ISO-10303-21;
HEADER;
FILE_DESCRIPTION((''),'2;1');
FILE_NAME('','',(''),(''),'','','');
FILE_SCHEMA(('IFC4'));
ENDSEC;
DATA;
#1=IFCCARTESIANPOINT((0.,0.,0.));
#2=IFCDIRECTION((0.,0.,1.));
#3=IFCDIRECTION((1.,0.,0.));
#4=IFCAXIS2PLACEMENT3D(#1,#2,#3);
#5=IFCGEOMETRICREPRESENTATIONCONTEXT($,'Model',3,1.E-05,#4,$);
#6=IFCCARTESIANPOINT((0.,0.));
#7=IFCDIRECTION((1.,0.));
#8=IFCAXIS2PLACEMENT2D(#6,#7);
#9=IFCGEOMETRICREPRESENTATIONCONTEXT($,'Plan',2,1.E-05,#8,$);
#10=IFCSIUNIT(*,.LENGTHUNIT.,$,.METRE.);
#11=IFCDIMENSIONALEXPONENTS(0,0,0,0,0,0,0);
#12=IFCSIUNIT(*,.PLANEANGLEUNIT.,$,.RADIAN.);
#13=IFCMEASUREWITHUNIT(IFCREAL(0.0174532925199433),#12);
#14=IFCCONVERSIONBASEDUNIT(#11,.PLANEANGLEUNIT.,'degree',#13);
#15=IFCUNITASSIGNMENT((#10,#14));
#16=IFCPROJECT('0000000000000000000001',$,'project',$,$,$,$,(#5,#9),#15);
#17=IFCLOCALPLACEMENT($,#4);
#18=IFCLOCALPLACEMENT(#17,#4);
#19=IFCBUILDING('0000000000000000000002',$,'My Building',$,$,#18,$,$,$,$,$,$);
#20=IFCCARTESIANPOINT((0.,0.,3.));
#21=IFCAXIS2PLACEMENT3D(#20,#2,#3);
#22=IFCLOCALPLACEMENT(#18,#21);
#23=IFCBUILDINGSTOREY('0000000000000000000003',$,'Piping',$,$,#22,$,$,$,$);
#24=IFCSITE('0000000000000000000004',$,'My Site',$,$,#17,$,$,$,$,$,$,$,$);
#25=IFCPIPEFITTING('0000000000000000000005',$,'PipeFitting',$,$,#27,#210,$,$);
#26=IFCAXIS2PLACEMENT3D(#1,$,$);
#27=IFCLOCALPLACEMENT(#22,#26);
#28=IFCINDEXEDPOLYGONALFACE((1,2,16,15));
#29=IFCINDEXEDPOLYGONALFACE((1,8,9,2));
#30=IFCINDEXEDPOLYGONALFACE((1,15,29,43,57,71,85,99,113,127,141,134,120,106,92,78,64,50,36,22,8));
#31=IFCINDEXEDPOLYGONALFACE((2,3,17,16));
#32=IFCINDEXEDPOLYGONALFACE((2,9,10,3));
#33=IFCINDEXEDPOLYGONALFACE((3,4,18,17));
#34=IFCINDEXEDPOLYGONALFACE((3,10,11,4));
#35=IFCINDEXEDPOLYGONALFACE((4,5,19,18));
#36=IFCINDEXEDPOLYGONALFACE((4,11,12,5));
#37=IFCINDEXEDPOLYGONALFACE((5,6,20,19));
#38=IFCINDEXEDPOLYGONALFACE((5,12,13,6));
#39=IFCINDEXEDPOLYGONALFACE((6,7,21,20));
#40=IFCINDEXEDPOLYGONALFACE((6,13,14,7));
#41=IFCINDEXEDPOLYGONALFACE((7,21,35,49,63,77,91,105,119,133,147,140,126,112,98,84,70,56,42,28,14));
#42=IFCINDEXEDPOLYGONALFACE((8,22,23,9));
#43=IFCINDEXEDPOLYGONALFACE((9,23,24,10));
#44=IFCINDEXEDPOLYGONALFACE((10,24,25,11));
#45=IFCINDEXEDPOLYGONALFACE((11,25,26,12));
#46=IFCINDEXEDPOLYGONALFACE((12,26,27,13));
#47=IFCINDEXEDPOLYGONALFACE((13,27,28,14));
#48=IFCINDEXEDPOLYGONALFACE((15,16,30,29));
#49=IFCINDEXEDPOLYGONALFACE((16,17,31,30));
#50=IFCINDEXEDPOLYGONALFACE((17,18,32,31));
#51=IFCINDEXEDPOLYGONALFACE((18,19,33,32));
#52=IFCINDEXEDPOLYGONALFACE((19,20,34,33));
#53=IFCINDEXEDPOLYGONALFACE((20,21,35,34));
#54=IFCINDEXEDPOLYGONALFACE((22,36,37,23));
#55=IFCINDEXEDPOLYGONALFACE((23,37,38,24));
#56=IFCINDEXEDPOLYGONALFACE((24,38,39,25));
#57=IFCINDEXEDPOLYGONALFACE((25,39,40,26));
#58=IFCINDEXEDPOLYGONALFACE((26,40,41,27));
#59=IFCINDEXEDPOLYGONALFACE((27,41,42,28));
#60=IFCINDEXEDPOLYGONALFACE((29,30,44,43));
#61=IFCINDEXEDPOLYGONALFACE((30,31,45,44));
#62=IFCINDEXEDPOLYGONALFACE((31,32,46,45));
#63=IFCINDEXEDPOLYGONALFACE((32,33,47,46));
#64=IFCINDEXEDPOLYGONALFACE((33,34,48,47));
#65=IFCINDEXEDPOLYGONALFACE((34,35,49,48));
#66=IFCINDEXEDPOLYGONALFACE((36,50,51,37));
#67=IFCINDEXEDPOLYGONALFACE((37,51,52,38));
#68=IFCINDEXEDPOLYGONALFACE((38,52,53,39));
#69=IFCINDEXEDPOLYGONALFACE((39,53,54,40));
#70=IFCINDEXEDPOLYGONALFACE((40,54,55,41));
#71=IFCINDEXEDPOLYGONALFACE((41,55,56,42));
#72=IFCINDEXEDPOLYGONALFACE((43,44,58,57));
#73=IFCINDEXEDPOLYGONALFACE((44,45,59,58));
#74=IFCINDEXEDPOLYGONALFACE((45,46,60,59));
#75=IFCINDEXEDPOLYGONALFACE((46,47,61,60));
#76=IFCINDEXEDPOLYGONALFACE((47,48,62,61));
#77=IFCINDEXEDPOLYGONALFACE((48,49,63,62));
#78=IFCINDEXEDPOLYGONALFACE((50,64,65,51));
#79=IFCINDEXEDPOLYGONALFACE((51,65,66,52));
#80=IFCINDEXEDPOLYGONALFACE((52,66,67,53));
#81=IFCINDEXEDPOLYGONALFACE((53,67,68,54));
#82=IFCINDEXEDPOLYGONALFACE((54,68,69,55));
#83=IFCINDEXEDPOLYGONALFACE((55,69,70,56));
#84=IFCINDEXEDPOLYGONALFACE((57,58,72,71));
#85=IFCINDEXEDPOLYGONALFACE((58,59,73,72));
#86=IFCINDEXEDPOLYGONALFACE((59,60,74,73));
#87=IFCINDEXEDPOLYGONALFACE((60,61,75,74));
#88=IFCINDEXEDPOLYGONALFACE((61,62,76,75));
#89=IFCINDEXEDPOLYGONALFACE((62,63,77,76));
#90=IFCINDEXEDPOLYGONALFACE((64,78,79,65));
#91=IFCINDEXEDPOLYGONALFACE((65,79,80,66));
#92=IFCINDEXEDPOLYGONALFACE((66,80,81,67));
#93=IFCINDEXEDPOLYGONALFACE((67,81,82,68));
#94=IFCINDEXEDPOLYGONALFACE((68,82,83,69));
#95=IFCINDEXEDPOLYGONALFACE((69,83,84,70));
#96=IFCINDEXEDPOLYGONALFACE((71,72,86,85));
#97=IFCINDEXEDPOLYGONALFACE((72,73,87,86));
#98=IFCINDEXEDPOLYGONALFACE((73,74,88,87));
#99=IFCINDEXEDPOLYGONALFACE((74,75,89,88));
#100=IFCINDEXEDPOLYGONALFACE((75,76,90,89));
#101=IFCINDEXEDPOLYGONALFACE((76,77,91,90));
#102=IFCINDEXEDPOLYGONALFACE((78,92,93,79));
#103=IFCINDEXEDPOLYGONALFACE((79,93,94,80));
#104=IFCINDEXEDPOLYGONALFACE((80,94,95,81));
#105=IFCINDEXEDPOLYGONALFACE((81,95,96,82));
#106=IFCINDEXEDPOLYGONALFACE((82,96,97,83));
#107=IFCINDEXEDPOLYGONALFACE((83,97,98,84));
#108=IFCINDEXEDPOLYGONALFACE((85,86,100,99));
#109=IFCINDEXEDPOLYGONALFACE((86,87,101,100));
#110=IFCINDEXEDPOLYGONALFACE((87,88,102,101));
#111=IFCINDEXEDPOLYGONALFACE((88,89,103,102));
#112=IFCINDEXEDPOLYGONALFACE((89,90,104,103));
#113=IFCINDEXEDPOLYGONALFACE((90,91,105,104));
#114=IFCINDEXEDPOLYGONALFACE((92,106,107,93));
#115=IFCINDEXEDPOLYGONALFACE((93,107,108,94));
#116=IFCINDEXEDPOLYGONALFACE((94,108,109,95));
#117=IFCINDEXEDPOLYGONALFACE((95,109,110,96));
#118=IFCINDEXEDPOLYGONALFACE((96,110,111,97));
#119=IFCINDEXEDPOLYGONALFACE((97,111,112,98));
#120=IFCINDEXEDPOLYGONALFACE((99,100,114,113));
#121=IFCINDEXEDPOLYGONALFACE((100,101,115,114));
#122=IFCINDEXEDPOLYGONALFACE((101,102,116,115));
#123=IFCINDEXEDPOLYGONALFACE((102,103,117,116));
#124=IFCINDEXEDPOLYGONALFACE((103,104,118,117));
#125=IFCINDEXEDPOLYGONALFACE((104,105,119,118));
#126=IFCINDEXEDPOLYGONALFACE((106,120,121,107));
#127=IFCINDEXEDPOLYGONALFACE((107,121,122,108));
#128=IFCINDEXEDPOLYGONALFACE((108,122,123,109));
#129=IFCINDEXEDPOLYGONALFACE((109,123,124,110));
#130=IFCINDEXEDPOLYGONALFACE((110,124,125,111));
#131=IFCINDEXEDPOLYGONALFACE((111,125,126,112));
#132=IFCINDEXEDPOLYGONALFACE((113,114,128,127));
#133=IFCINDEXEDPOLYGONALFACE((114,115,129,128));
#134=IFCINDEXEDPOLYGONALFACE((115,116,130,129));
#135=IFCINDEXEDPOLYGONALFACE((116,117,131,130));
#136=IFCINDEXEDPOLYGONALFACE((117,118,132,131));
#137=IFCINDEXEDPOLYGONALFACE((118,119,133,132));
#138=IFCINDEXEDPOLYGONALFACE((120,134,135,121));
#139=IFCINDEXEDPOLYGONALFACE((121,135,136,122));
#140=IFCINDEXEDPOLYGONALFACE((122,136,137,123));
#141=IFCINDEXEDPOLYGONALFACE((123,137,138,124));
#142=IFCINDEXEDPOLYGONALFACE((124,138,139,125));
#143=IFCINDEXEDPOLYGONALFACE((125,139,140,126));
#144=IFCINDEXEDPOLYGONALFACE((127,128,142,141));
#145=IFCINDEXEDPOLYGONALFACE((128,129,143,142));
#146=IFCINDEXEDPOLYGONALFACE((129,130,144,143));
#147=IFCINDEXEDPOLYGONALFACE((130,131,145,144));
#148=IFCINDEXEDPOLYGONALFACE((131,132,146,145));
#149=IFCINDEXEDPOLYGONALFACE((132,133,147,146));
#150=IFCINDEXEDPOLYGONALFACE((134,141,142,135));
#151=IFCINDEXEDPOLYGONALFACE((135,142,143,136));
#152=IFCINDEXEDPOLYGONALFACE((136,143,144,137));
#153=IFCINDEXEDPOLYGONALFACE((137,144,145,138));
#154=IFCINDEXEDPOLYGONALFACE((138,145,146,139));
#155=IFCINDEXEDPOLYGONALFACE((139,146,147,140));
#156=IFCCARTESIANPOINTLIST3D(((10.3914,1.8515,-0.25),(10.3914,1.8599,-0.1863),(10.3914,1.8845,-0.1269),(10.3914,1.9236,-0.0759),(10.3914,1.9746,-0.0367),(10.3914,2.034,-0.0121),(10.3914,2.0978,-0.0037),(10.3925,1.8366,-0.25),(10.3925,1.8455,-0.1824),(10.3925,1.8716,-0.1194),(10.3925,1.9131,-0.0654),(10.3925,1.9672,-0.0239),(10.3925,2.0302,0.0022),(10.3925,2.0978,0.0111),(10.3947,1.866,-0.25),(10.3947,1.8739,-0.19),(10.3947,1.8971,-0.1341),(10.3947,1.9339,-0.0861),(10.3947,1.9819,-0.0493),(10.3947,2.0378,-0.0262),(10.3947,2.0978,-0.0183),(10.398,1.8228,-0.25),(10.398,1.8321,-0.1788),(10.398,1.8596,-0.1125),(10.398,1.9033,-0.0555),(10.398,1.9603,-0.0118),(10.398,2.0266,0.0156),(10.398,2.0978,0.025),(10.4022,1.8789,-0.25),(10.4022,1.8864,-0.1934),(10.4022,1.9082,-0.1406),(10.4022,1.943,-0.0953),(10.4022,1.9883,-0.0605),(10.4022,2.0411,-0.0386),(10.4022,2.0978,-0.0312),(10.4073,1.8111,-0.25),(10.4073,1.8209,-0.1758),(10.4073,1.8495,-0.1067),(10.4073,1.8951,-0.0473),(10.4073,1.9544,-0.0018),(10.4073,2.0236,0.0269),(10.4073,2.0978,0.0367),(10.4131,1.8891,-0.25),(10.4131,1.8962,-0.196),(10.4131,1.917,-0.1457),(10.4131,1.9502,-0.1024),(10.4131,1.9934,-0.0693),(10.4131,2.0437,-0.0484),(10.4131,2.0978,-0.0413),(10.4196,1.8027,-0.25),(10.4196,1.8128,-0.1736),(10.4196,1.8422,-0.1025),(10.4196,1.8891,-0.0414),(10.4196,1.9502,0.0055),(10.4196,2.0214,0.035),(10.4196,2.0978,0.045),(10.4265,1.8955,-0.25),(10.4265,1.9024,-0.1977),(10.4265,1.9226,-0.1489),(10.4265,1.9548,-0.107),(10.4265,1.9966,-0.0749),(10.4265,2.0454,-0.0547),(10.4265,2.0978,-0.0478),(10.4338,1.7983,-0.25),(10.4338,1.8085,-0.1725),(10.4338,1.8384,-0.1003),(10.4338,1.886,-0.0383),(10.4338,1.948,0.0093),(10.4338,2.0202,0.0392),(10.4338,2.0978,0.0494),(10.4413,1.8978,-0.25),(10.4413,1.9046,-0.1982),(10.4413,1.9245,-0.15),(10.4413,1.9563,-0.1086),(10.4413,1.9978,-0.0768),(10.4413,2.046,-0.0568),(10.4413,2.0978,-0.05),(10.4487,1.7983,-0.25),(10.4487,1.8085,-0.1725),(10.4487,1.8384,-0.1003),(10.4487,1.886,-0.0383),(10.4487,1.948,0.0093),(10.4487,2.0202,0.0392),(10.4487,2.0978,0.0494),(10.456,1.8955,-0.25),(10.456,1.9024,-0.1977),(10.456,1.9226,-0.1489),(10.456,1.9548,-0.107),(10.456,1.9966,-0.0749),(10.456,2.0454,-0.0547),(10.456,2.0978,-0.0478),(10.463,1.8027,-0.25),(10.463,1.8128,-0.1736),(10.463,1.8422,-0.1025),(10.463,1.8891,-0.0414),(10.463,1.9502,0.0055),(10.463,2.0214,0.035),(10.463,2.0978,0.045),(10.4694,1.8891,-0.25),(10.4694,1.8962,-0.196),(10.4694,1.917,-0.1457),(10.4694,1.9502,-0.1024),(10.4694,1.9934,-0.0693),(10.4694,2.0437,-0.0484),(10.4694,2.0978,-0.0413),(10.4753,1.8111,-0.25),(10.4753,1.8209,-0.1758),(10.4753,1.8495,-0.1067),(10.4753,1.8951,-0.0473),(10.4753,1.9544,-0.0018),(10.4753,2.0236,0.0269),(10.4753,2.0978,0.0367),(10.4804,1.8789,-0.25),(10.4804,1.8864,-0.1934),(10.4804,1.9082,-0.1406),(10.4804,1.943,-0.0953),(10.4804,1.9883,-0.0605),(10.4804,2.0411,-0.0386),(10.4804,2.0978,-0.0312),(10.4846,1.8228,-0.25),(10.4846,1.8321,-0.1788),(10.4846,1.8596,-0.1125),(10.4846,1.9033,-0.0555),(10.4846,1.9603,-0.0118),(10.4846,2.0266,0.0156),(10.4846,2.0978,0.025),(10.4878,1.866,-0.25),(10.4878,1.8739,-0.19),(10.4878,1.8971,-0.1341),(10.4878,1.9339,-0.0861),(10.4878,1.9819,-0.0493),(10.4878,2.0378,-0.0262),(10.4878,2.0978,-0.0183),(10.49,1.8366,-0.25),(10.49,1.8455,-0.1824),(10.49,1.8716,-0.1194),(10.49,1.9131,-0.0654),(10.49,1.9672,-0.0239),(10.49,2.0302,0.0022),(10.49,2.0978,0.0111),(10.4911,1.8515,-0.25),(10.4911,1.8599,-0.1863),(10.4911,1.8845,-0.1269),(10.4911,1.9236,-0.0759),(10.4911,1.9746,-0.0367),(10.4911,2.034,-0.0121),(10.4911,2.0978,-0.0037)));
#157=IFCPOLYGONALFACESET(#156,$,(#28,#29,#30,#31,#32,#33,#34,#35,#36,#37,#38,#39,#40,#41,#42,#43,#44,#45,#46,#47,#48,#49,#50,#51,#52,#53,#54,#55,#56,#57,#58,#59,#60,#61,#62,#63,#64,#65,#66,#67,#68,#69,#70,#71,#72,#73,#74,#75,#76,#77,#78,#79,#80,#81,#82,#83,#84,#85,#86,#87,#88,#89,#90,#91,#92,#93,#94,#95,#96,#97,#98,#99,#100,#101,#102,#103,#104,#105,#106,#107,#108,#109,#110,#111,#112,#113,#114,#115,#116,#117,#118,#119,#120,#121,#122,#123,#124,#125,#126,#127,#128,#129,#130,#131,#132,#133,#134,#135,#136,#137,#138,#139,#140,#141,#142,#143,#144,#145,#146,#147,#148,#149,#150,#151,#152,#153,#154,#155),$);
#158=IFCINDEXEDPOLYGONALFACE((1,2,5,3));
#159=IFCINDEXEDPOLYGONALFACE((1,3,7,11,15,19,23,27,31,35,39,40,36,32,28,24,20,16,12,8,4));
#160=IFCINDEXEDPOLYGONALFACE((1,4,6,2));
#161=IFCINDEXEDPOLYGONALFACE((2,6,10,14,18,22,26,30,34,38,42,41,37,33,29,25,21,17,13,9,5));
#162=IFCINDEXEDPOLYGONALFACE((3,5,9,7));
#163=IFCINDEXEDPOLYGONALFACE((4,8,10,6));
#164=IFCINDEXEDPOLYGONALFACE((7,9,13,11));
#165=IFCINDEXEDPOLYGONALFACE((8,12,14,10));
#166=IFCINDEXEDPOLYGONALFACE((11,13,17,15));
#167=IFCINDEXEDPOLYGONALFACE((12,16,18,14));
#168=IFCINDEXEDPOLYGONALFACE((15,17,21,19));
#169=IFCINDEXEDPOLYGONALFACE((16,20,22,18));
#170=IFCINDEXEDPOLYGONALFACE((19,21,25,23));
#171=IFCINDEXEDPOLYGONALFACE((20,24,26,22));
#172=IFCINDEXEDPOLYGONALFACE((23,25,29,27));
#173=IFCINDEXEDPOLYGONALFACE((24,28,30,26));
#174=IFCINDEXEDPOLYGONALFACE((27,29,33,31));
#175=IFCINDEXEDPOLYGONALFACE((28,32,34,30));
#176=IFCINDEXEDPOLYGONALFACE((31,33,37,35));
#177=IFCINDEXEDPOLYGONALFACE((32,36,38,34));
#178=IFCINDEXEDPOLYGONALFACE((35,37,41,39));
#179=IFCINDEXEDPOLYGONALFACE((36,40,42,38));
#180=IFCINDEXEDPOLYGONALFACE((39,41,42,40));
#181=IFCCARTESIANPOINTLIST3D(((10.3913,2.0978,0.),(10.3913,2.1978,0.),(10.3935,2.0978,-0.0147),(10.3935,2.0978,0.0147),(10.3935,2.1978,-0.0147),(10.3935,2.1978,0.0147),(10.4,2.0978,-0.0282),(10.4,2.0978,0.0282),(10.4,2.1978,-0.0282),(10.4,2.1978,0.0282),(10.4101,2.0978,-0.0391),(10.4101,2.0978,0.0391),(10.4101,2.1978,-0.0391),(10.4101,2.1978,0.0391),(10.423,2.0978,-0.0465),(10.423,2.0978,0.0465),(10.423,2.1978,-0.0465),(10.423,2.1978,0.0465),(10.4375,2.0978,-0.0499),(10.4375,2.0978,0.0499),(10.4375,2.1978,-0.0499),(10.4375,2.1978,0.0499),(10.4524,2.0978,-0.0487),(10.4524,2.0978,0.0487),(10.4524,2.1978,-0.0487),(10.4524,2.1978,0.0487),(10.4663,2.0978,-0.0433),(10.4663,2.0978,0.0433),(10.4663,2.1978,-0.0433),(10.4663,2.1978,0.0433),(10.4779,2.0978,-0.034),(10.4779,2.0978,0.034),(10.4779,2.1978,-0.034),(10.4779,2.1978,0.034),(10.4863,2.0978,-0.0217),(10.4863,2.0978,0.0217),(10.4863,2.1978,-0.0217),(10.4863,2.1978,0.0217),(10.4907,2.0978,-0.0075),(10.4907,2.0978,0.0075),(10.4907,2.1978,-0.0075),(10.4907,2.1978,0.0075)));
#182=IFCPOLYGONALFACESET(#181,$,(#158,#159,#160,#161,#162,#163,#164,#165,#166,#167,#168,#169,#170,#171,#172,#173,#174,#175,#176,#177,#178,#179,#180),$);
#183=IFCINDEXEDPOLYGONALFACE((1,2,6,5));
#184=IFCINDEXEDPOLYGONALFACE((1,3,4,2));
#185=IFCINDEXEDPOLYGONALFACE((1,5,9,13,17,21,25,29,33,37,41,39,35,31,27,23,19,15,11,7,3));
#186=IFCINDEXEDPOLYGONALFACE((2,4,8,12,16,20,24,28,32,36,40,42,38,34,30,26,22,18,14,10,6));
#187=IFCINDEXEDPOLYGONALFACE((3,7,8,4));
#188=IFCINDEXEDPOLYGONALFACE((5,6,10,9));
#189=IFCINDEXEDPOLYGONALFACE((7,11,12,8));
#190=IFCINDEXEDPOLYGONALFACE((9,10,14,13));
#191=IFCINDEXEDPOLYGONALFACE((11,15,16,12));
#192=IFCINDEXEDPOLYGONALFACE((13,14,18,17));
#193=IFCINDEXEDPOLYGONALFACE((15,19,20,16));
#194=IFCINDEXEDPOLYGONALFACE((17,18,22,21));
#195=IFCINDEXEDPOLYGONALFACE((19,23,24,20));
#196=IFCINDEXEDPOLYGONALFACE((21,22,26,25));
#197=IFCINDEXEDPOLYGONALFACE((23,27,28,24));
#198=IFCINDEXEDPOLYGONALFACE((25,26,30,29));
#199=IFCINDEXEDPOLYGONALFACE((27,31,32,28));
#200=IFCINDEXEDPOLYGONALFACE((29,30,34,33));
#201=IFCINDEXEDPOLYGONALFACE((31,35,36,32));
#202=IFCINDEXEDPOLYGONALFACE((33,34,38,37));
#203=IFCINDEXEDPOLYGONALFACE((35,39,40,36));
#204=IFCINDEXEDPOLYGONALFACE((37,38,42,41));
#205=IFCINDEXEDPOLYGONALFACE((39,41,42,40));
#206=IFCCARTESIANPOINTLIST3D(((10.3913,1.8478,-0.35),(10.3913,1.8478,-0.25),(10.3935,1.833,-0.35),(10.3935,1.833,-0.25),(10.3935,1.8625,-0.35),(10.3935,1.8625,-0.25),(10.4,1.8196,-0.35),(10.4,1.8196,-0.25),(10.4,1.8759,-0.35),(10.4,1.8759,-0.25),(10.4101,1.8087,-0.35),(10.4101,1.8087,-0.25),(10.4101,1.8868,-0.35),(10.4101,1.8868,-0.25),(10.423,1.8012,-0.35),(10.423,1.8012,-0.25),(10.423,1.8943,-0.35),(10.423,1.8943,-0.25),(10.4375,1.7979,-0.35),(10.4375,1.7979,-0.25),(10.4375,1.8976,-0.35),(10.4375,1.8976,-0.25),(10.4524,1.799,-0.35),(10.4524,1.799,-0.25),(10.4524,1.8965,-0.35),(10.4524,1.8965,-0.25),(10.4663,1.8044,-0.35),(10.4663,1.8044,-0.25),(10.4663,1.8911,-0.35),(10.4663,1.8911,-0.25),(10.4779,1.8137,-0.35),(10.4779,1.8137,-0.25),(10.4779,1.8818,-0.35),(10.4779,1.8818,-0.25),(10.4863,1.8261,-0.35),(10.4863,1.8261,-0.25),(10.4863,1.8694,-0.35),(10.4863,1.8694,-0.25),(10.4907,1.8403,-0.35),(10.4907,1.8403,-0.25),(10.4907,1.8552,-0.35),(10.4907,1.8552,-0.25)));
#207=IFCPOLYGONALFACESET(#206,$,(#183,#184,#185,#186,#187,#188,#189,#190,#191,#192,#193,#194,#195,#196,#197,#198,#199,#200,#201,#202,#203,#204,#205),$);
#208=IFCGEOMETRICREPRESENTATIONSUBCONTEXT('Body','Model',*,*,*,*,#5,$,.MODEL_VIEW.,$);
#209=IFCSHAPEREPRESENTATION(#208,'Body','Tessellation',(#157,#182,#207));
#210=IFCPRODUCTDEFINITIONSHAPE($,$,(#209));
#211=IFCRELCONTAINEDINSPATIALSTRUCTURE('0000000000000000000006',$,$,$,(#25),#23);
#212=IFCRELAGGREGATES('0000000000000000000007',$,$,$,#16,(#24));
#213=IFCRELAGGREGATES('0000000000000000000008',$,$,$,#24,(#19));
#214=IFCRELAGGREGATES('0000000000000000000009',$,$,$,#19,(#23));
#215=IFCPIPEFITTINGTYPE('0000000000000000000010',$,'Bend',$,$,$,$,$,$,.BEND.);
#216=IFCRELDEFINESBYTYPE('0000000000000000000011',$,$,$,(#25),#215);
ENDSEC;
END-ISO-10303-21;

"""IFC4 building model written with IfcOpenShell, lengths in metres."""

from ifc_helpers import new_model, entity, si_unit, converted_unit, frame, origin_with_axes, origin_2d_with_axis, place, context, subcontext, project, spatial, circle, extrude, source, transform, mapped, type_object, type_shapes, element, save


model = new_model("IFC4")

# Units and contexts
model_context = context("Model", 3, precision=1e-05, world=origin_with_axes())
plan_context = context("Plan", 2, precision=1e-05, world=origin_2d_with_axis())
body_context = subcontext(model_context, "Body", "Model", "MODEL_VIEW")
ifc_project = project(units=[si_unit("LENGTHUNIT", "METRE"), converted_unit("PLANEANGLEUNIT", "degree", entity("IfcReal", 0.0174532925199433), si_unit("PLANEANGLEUNIT", "RADIAN"), dimensions=[0, 0, 0, 0, 0, 0, 0])], contexts=[model_context, plan_context])

# Site, building, storey
site_placement = place(None, origin_with_axes())
site = spatial("IfcSite", under=ifc_project, at=site_placement, Name="My Site")
building_placement = place(site_placement, origin_with_axes())
building = spatial("IfcBuilding", under=site, at=building_placement, Name="My Building")
storey_placement = place(building_placement, frame((0.0, 0.0, 3.0), z_axis=(0.0, 0.0, 1.0), x_axis=(1.0, 0.0, 0.0)))
storey = spatial("IfcBuildingStorey", under=building, at=storey_placement, Name="Piping")

# Pipe fitting
pipe_fitting_type = type_object("IfcPipeFittingType", Name="Bend", PredefinedType="BEND")
shared_shape = source(origin_with_axes(), body_context, "Body", "SolidModel", [
    entity("IfcSweptDiskSolid", entity("IfcIndexedPolyCurve", entity("IfcCartesianPointList3D", [[0.0, 0.0, -0.1], [0.0, -0.0732, -0.2768], [0.0, -0.25, -0.35]]), [entity("IfcArcIndex", [1, 2, 3])]), 0.05),
    extrude(circle(Radius=0.05), origin_with_axes(), (0.0, 0.0, -1.0), 0.1),
    extrude(circle(Radius=0.05), frame((0.0, -0.25, -0.35), z_axis=(0.0, -1.0, 0.0), x_axis=(1.0, 0.0, 0.0)), (0.0, 0.0, 1.0), 0.1),
])
type_shapes(pipe_fitting_type, [shared_shape])
for number, where, z_axis, x_axis, name in (
    (1, (10.4413, 2.1978, 0.0), (0.0, 1.0, 0.0), (-1.0, 0.0, 0.0), "PipeFitting"),
):
    element("IfcPipeFitting", number, at=place(storey_placement, frame(where, z_axis=z_axis, x_axis=x_axis)), inside=storey, type_object=pipe_fitting_type, Name=name, context=body_context, shape_type="MappedRepresentation", body=[
        mapped(shared_shape, transform((0.0, 0.0, 0.0), x_axis=(1.0, 0.0, 0.0), y_axis=(0.0, 1.0, 0.0), z_axis=(0.0, 0.0, 1.0), scale=1.0)),
    ])

save(model, "model.ifc")
